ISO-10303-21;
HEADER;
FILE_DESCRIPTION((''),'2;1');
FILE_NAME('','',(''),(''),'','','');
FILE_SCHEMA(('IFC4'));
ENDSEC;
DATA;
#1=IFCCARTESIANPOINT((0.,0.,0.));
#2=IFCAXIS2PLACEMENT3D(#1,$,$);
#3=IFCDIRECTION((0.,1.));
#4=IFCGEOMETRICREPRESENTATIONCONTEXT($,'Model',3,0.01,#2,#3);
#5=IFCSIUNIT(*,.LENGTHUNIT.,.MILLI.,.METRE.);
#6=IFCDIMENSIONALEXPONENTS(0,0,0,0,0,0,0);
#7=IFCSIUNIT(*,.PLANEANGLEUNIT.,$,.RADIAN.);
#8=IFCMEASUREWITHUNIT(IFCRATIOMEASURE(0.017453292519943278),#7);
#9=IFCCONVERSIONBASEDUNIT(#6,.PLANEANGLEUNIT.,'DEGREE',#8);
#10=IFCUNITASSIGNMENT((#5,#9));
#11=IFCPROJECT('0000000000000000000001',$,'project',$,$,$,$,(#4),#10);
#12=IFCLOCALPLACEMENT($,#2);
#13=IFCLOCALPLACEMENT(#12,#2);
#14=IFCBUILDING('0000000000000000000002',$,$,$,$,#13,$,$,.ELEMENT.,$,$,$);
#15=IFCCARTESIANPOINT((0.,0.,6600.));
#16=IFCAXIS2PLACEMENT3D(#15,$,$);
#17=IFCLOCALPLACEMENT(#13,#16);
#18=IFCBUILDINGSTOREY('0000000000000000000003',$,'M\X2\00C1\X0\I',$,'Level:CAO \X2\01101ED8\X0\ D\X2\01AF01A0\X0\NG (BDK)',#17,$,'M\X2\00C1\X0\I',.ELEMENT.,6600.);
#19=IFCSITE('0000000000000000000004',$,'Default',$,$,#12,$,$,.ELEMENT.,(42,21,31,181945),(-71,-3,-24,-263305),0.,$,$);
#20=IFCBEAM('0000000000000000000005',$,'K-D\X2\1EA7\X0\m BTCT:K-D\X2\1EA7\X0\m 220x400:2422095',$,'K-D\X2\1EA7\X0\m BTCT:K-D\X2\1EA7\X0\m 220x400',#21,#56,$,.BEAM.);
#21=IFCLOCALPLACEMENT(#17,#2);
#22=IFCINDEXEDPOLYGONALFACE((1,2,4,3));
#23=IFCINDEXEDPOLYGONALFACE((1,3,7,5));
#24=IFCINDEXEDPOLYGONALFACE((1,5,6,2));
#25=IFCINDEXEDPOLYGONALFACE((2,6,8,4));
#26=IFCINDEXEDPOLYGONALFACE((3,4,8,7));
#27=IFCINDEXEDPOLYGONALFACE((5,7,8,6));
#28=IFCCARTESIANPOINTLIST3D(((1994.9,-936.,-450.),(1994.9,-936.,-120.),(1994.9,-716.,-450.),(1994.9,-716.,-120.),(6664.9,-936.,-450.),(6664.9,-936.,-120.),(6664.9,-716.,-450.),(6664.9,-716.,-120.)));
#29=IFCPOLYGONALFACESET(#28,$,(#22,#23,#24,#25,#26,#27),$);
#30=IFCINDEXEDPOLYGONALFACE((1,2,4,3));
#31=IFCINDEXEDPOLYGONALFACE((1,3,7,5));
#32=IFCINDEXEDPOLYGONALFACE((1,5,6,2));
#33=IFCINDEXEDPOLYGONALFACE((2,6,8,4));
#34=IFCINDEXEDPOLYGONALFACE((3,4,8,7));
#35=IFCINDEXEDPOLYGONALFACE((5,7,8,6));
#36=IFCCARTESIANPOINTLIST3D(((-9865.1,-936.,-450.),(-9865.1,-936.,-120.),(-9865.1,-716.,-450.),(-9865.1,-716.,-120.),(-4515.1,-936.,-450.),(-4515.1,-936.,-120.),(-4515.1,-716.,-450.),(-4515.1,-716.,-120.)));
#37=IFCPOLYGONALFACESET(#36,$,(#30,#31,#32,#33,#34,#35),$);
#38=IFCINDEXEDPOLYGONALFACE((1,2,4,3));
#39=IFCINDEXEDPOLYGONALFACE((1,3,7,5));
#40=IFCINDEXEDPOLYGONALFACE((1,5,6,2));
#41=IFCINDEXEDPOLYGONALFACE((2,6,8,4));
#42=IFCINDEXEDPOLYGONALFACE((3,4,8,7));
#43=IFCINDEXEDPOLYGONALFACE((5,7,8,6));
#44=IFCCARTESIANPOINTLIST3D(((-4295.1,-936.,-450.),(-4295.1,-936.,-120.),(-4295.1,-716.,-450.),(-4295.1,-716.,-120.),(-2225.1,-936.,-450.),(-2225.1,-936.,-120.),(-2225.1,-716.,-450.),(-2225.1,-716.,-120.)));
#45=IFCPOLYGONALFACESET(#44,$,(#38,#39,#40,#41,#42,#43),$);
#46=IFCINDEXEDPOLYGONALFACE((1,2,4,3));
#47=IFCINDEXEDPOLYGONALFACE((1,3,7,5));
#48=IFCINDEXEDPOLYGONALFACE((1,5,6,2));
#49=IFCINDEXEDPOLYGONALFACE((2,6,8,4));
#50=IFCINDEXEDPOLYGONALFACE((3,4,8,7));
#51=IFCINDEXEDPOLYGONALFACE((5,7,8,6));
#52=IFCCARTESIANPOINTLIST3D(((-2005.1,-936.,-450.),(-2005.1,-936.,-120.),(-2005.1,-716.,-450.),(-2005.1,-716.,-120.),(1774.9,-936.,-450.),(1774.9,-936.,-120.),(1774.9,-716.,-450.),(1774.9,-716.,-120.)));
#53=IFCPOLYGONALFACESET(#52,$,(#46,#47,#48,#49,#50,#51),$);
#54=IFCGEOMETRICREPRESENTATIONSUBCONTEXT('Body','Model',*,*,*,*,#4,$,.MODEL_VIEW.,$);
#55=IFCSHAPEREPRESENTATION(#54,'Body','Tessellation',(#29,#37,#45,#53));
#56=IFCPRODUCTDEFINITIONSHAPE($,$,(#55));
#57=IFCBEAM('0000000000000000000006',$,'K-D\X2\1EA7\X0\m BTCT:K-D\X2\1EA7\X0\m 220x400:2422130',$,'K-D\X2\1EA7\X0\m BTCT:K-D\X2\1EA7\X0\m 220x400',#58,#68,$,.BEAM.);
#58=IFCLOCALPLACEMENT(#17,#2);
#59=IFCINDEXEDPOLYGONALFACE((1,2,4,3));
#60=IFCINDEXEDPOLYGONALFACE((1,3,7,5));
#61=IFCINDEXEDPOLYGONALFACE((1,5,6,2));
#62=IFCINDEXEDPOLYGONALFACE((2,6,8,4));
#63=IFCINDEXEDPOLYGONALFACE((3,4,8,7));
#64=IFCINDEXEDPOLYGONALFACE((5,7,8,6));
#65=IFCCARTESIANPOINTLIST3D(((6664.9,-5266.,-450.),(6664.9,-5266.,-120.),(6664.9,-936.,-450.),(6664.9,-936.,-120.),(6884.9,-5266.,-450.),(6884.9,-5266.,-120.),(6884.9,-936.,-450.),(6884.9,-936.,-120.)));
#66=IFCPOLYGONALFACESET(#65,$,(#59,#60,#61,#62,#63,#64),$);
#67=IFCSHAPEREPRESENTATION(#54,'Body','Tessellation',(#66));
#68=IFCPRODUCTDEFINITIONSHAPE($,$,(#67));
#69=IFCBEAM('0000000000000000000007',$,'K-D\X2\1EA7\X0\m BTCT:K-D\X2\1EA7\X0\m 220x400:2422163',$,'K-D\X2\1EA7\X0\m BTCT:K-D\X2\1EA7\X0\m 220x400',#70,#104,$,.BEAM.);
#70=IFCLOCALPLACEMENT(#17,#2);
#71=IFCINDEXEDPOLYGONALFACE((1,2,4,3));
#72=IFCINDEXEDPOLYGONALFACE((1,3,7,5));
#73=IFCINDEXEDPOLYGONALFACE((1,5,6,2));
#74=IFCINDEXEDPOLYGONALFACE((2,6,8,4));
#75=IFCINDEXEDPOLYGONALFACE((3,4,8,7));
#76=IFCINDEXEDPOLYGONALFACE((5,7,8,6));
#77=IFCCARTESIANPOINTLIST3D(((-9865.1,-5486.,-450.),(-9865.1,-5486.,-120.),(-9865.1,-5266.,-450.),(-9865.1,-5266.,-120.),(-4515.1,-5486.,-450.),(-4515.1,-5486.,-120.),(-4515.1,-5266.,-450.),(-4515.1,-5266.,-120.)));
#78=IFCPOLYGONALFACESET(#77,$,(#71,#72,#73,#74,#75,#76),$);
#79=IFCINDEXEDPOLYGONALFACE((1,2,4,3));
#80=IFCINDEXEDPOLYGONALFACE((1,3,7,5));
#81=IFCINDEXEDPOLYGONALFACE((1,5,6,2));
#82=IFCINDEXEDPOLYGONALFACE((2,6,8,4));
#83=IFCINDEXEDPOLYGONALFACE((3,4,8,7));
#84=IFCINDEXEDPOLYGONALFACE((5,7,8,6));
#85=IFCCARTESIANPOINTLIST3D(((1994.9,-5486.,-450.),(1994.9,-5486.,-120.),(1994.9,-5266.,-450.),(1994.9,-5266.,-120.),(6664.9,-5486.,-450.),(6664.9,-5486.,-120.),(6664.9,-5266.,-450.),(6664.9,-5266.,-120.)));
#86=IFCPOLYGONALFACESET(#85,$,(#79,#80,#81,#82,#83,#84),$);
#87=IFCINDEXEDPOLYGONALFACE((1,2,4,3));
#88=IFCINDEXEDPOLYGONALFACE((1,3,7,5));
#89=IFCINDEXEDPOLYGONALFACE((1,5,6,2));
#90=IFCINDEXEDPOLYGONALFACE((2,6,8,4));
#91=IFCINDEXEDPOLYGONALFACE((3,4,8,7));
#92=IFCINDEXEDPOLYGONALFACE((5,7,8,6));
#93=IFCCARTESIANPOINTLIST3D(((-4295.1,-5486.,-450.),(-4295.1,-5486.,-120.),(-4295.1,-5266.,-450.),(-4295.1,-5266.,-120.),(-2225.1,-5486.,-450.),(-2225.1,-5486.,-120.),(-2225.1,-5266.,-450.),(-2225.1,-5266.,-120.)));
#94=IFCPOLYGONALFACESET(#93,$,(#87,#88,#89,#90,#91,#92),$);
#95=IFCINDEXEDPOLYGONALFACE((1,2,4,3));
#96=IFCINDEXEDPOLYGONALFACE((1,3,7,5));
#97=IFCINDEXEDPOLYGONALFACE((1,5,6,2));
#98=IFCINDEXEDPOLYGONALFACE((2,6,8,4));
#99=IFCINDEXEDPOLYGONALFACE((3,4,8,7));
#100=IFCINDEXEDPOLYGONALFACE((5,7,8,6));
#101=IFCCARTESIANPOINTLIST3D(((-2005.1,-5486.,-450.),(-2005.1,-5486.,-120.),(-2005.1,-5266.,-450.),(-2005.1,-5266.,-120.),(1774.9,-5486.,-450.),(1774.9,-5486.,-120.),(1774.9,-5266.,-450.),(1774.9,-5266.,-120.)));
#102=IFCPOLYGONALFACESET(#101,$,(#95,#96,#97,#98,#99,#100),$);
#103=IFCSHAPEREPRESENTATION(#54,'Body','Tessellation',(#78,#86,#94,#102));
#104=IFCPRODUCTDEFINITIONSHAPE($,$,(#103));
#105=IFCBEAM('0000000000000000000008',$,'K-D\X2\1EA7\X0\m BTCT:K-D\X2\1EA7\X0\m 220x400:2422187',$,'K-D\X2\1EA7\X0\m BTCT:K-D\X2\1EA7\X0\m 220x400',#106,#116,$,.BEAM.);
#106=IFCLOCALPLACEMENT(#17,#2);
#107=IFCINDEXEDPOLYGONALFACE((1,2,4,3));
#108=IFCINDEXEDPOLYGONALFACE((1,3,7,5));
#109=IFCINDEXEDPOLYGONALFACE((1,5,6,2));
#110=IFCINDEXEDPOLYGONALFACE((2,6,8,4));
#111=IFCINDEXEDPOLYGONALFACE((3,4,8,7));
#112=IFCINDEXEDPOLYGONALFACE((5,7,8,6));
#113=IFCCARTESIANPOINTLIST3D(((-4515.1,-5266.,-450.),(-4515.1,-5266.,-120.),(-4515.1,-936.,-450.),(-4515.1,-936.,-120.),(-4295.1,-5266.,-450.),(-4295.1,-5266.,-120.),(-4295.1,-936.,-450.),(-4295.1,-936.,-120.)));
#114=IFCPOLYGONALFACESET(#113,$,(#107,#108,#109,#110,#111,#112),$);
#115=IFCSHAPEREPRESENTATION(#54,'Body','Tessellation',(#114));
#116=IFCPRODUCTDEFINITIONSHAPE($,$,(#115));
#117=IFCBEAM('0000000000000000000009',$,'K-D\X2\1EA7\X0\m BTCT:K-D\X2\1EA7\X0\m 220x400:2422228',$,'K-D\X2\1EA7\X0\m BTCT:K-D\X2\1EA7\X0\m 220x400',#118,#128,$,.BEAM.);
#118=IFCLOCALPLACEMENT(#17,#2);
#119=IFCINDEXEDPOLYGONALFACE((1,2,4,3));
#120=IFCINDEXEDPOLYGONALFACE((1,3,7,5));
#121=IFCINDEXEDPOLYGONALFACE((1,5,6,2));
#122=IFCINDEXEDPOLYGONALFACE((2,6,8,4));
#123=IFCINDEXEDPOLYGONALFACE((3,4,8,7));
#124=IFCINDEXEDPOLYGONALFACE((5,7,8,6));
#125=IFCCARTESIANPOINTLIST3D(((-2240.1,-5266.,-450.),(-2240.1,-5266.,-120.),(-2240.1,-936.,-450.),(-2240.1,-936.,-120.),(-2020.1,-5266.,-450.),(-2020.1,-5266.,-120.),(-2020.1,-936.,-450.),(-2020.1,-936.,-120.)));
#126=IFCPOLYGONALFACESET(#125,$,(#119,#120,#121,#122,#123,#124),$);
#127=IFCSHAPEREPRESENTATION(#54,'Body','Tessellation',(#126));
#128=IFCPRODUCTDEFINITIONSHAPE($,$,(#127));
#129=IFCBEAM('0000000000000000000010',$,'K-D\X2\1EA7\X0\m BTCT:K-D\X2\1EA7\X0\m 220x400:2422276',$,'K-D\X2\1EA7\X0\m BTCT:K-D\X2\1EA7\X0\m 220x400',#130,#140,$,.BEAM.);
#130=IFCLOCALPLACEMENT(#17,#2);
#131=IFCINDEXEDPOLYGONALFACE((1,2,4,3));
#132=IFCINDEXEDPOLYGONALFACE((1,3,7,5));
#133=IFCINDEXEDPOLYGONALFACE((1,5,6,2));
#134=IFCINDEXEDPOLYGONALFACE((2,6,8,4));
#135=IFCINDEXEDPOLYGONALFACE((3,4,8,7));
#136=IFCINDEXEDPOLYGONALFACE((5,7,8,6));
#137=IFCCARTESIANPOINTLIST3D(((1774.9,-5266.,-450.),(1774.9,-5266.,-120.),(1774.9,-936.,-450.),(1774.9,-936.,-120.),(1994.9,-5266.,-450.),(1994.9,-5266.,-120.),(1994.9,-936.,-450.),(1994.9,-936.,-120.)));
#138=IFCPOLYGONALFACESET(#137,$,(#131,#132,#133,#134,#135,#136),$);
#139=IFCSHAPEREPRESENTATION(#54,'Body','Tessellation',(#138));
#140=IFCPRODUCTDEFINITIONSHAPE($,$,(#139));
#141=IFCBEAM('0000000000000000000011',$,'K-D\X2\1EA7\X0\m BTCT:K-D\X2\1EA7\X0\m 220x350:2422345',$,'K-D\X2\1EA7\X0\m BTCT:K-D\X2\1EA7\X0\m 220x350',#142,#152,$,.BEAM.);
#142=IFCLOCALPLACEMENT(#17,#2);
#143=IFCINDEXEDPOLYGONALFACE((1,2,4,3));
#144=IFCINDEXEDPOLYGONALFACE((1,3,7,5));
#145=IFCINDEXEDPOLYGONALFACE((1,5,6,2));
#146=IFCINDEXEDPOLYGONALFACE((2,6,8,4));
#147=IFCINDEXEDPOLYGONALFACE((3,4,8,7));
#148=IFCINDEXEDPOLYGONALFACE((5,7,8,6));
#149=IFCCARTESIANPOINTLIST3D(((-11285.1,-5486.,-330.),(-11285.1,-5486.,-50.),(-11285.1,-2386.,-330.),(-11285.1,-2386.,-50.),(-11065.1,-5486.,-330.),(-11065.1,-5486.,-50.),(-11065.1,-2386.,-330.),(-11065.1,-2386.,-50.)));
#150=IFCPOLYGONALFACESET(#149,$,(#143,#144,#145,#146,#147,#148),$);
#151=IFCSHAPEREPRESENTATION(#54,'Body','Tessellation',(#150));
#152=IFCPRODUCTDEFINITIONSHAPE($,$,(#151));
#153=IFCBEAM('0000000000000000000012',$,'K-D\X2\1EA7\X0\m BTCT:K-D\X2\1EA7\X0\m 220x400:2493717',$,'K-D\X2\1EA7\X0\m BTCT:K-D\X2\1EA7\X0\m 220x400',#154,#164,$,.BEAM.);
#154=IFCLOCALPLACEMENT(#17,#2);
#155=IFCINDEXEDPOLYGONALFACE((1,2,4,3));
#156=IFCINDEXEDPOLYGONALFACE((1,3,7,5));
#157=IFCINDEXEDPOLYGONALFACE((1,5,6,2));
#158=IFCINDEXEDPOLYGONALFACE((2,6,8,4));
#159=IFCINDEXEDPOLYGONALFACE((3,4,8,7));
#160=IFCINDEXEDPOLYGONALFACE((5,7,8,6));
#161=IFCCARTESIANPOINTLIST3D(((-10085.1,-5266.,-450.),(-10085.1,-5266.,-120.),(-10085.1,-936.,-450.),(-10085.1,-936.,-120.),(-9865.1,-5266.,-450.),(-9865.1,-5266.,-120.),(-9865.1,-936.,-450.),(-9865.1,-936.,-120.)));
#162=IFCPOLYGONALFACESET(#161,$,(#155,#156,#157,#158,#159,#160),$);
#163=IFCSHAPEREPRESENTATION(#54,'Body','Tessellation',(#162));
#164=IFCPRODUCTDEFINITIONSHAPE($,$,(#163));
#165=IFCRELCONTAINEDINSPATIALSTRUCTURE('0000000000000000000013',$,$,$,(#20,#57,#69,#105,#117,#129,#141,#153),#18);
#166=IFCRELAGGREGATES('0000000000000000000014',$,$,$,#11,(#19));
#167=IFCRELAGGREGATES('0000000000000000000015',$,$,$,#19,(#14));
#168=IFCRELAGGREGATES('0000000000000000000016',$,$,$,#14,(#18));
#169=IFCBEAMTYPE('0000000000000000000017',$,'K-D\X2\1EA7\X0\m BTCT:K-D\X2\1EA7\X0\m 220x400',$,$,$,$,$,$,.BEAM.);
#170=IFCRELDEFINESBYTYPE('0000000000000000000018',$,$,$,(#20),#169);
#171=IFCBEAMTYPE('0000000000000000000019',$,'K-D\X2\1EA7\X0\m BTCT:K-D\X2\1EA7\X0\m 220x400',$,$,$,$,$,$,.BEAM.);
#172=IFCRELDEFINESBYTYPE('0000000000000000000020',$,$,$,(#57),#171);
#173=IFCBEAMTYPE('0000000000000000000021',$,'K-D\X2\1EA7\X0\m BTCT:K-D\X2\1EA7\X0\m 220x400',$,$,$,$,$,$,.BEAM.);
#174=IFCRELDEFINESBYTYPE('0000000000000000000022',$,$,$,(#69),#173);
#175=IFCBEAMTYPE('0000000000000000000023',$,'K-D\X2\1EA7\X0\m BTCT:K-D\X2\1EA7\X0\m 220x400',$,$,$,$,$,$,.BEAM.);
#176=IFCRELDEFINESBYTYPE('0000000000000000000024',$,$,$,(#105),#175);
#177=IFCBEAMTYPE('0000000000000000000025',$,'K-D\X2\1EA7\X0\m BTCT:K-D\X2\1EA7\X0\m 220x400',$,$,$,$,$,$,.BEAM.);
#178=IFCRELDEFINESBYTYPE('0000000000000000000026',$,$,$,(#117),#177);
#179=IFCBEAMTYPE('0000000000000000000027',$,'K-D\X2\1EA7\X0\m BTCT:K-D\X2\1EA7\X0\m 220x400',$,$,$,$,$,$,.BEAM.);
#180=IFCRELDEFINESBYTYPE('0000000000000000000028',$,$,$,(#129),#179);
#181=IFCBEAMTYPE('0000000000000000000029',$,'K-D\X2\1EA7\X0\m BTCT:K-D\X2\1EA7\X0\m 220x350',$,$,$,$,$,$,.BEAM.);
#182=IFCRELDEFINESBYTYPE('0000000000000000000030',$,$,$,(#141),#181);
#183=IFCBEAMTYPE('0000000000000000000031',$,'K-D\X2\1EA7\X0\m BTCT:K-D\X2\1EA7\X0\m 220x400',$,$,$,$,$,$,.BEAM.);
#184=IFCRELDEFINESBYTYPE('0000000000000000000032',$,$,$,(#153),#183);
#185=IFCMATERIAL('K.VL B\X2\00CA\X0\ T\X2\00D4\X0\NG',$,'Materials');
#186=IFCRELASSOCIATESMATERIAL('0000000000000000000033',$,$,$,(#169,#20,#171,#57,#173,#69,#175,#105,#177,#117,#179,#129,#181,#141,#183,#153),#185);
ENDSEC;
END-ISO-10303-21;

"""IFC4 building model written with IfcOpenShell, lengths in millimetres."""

from ifc_helpers import new_model, entity, si_unit, converted_unit, direction, frame, origin, place, context, subcontext, project, spatial, indexed_curve, outline, extrude, source, transform, mapped, material, type_object, type_shapes, element, save


model = new_model("IFC4")

# Units and contexts
model_context = context("Model", 3, precision=0.01, world=origin(), true_north=direction((0.0, 1.0)))
body_context = subcontext(model_context, "Body", "Model", "MODEL_VIEW")
ifc_project = project(units=[si_unit("LENGTHUNIT", "METRE", prefix="MILLI"), converted_unit("PLANEANGLEUNIT", "DEGREE", entity("IfcRatioMeasure", 0.017453292519943278), si_unit("PLANEANGLEUNIT", "RADIAN"), dimensions=[0, 0, 0, 0, 0, 0, 0])], contexts=[model_context])

# Site, building, storey
site_placement = place(None, origin())
site = spatial("IfcSite", under=ifc_project, at=site_placement, Name="Default", CompositionType="ELEMENT", RefLatitude=(42, 21, 31, 181945), RefLongitude=(-71, -3, -24, -263305), RefElevation=0.0)
building_placement = place(site_placement, origin())
building = spatial("IfcBuilding", under=site, at=building_placement, CompositionType="ELEMENT")
storey_placement = place(building_placement, frame((0.0, 0.0, 6600.0)))
storey = spatial("IfcBuildingStorey", under=building, at=storey_placement, Name="MÁI", ObjectType="Level:CAO ĐỘ DƯƠNG (BDK)", LongName="MÁI", CompositionType="ELEMENT", Elevation=6600.0)

# Beams
ifc_material_1 = material(Name="K.VL BÊ TÔNG", Category="Materials")
beam_type_1 = type_object("IfcBeamType", Name="K-Dầm BTCT:K-Dầm 220x400", PredefinedType="BEAM", material=ifc_material_1)
shared_shape_1 = source(origin(), body_context, "Body", "SweptSolid", [
    extrude(outline(indexed_curve([(-165.0, -110.0), (165.0, -110.0), (165.0, 110.0), (-165.0, 110.0), (-165.0, -110.0)], self_intersect=False)), frame((1994.9, -826.0, 6315.0), z_axis=(1.0, 0.0, 0.0), x_axis=(0.0, 0.0, -1.0)), (0.0, 0.0, 1.0), 4670.0),
    extrude(outline(indexed_curve([(-165.0, -110.0), (165.0, -110.0), (165.0, 110.0), (-165.0, 110.0), (-165.0, -110.0)], self_intersect=False)), frame((-9865.1, -826.0, 6315.0), z_axis=(1.0, 0.0, 0.0), x_axis=(0.0, 0.0, -1.0)), (0.0, 0.0, 1.0), 5350.0),
    extrude(outline(indexed_curve([(-165.0, -110.0), (165.0, -110.0), (165.0, 110.0), (-165.0, 110.0), (-165.0, -110.0)], self_intersect=False)), frame((-4295.1, -826.0, 6315.0), z_axis=(1.0, 0.0, 0.0), x_axis=(0.0, 0.0, -1.0)), (0.0, 0.0, 1.0), 2070.0),
    extrude(outline(indexed_curve([(-165.0, -110.0), (165.0, -110.0), (165.0, 110.0), (-165.0, 110.0), (-165.0, -110.0)], self_intersect=False)), frame((-2005.1, -826.0, 6315.0), z_axis=(1.0, 0.0, 0.0), x_axis=(0.0, 0.0, -1.0)), (0.0, 0.0, 1.0), 3780.0),
])
type_shapes(beam_type_1, [shared_shape_1])
beam_1_placement = place(storey_placement, frame((0.0, 0.0, -6600.0)))
element("IfcBeam", 1, at=beam_1_placement, inside=storey, type_object=beam_type_1, material=ifc_material_1, Name="K-Dầm BTCT:K-Dầm 220x400:2422095", ObjectType="K-Dầm BTCT:K-Dầm 220x400", PredefinedType="BEAM", context=body_context, shape_type="MappedRepresentation", body=[
    mapped(shared_shape_1, transform((0.0, 0.0, 0.0), scale=1.0)),
])
beam_type_2 = type_object("IfcBeamType", Name="K-Dầm BTCT:K-Dầm 220x400", PredefinedType="BEAM", material=ifc_material_1)
shared_shape_2 = source(origin(), body_context, "Body", "SweptSolid", [
    extrude(outline(indexed_curve([(-110.0, -165.0), (110.0, -165.0), (110.0, 165.0), (-110.0, 165.0), (-110.0, -165.0)], self_intersect=False)), frame((6774.9, -936.0, 6315.0), z_axis=(0.0, -1.0, 0.0), x_axis=(-1.0, 0.0, 0.0)), (0.0, 0.0, 1.0), 4330.0),
])
type_shapes(beam_type_2, [shared_shape_2])
beam_2_placement = place(storey_placement, frame((0.0, 0.0, -6600.0)))
element("IfcBeam", 2, at=beam_2_placement, inside=storey, type_object=beam_type_2, material=ifc_material_1, Name="K-Dầm BTCT:K-Dầm 220x400:2422130", ObjectType="K-Dầm BTCT:K-Dầm 220x400", PredefinedType="BEAM", context=body_context, shape_type="MappedRepresentation", body=[
    mapped(shared_shape_2, transform((0.0, 0.0, 0.0), scale=1.0)),
])
beam_type_3 = type_object("IfcBeamType", Name="K-Dầm BTCT:K-Dầm 220x400", PredefinedType="BEAM", material=ifc_material_1)
shared_shape_3 = source(origin(), body_context, "Body", "SweptSolid", [
    extrude(outline(indexed_curve([(-165.0, -110.0), (165.0, -110.0), (165.0, 110.0), (-165.0, 110.0), (-165.0, -110.0)], self_intersect=False)), frame((-4515.1, -5376.0, 6315.0), z_axis=(-1.0, 0.0, 0.0), x_axis=(0.0, 0.0, -1.0)), (0.0, 0.0, 1.0), 5350.0),
    extrude(outline(indexed_curve([(-165.0, -110.0), (165.0, -110.0), (165.0, 110.0), (-165.0, 110.0), (-165.0, -110.0)], self_intersect=False)), frame((6664.9, -5376.0, 6315.0), z_axis=(-1.0, 0.0, 0.0), x_axis=(0.0, 0.0, -1.0)), (0.0, 0.0, 1.0), 4670.0),
    extrude(outline(indexed_curve([(-165.0, -110.0), (165.0, -110.0), (165.0, 110.0), (-165.0, 110.0), (-165.0, -110.0)], self_intersect=False)), frame((-2225.1, -5376.0, 6315.0), z_axis=(-1.0, 0.0, 0.0), x_axis=(0.0, 0.0, -1.0)), (0.0, 0.0, 1.0), 2070.0),
    extrude(outline(indexed_curve([(-165.0, -110.0), (165.0, -110.0), (165.0, 110.0), (-165.0, 110.0), (-165.0, -110.0)], self_intersect=False)), frame((1774.9, -5376.0, 6315.0), z_axis=(-1.0, 0.0, 0.0), x_axis=(0.0, 0.0, -1.0)), (0.0, 0.0, 1.0), 3780.0),
])
type_shapes(beam_type_3, [shared_shape_3])
beam_3_placement = place(storey_placement, frame((0.0, 0.0, -6600.0)))
element("IfcBeam", 3, at=beam_3_placement, inside=storey, type_object=beam_type_3, material=ifc_material_1, Name="K-Dầm BTCT:K-Dầm 220x400:2422163", ObjectType="K-Dầm BTCT:K-Dầm 220x400", PredefinedType="BEAM", context=body_context, shape_type="MappedRepresentation", body=[
    mapped(shared_shape_3, transform((0.0, 0.0, 0.0), scale=1.0)),
])
beam_type_4 = type_object("IfcBeamType", Name="K-Dầm BTCT:K-Dầm 220x400", PredefinedType="BEAM", material=ifc_material_1)
shared_shape_4 = source(origin(), body_context, "Body", "SweptSolid", [
    extrude(outline(indexed_curve([(-110.0, -165.0), (110.0, -165.0), (110.0, 165.0), (-110.0, 165.0), (-110.0, -165.0)], self_intersect=False)), frame((-4405.1, -936.0, 6315.0), z_axis=(0.0, -1.0, 0.0), x_axis=(-1.0, 0.0, 0.0)), (0.0, 0.0, 1.0), 4330.0),
])
type_shapes(beam_type_4, [shared_shape_4])
beam_4_placement = place(storey_placement, frame((0.0, 0.0, -6600.0)))
element("IfcBeam", 4, at=beam_4_placement, inside=storey, type_object=beam_type_4, material=ifc_material_1, Name="K-Dầm BTCT:K-Dầm 220x400:2422187", ObjectType="K-Dầm BTCT:K-Dầm 220x400", PredefinedType="BEAM", context=body_context, shape_type="MappedRepresentation", body=[
    mapped(shared_shape_4, transform((0.0, 0.0, 0.0), scale=1.0)),
])
beam_type_5 = type_object("IfcBeamType", Name="K-Dầm BTCT:K-Dầm 220x400", PredefinedType="BEAM", material=ifc_material_1)
shared_shape_5 = source(origin(), body_context, "Body", "SweptSolid", [
    extrude(outline(indexed_curve([(-110.0, -165.0), (110.0, -165.0), (110.0, 165.0), (-110.0, 165.0), (-110.0, -165.0)], self_intersect=False)), frame((-2130.1, -936.0, 6315.0), z_axis=(0.0, -1.0, 0.0), x_axis=(-1.0, 0.0, 0.0)), (0.0, 0.0, 1.0), 4330.0),
])
type_shapes(beam_type_5, [shared_shape_5])
beam_5_placement = place(storey_placement, frame((0.0, 0.0, -6600.0)))
element("IfcBeam", 5, at=beam_5_placement, inside=storey, type_object=beam_type_5, material=ifc_material_1, Name="K-Dầm BTCT:K-Dầm 220x400:2422228", ObjectType="K-Dầm BTCT:K-Dầm 220x400", PredefinedType="BEAM", context=body_context, shape_type="MappedRepresentation", body=[
    mapped(shared_shape_5, transform((0.0, 0.0, 0.0), scale=1.0)),
])
beam_type_6 = type_object("IfcBeamType", Name="K-Dầm BTCT:K-Dầm 220x400", PredefinedType="BEAM", material=ifc_material_1)
shared_shape_6 = source(origin(), body_context, "Body", "SweptSolid", [
    extrude(outline(indexed_curve([(-110.0, -165.0), (110.0, -165.0), (110.0, 165.0), (-110.0, 165.0), (-110.0, -165.0)], self_intersect=False)), frame((1884.9, -936.0, 6315.0), z_axis=(0.0, -1.0, 0.0), x_axis=(-1.0, 0.0, 0.0)), (0.0, 0.0, 1.0), 4330.0),
])
type_shapes(beam_type_6, [shared_shape_6])
beam_6_placement = place(storey_placement, frame((0.0, 0.0, -6600.0)))
element("IfcBeam", 6, at=beam_6_placement, inside=storey, type_object=beam_type_6, material=ifc_material_1, Name="K-Dầm BTCT:K-Dầm 220x400:2422276", ObjectType="K-Dầm BTCT:K-Dầm 220x400", PredefinedType="BEAM", context=body_context, shape_type="MappedRepresentation", body=[
    mapped(shared_shape_6, transform((0.0, 0.0, 0.0), scale=1.0)),
])
beam_type_7 = type_object("IfcBeamType", Name="K-Dầm BTCT:K-Dầm 220x350", PredefinedType="BEAM", material=ifc_material_1)
shared_shape_7 = source(origin(), body_context, "Body", "SweptSolid", [
    extrude(outline(indexed_curve([(-110.0, -140.0), (110.0, -140.0), (110.0, 140.0), (-110.0, 140.0), (-110.0, -140.0)], self_intersect=False)), frame((-11175.1, -5486.0, 6410.0), z_axis=(0.0, 1.0, 0.0), x_axis=(-1.0, 0.0, 0.0)), (0.0, 0.0, 1.0), 3100.0),
])
type_shapes(beam_type_7, [shared_shape_7])
beam_7_placement = place(storey_placement, frame((0.0, 0.0, -6600.0)))
element("IfcBeam", 7, at=beam_7_placement, inside=storey, type_object=beam_type_7, material=ifc_material_1, Name="K-Dầm BTCT:K-Dầm 220x350:2422345", ObjectType="K-Dầm BTCT:K-Dầm 220x350", PredefinedType="BEAM", context=body_context, shape_type="MappedRepresentation", body=[
    mapped(shared_shape_7, transform((0.0, 0.0, 0.0), scale=1.0)),
])
beam_type_8 = type_object("IfcBeamType", Name="K-Dầm BTCT:K-Dầm 220x400", PredefinedType="BEAM", material=ifc_material_1)
shared_shape_8 = source(origin(), body_context, "Body", "SweptSolid", [
    extrude(outline(indexed_curve([(-110.0, -165.0), (110.0, -165.0), (110.0, 165.0), (-110.0, 165.0), (-110.0, -165.0)], self_intersect=False)), frame((-9975.1, -936.0, 6315.0), z_axis=(0.0, -1.0, 0.0), x_axis=(-1.0, 0.0, 0.0)), (0.0, 0.0, 1.0), 4330.0),
])
type_shapes(beam_type_8, [shared_shape_8])
beam_8_placement = place(storey_placement, frame((0.0, 0.0, -6600.0)))
element("IfcBeam", 8, at=beam_8_placement, inside=storey, type_object=beam_type_8, material=ifc_material_1, Name="K-Dầm BTCT:K-Dầm 220x400:2493717", ObjectType="K-Dầm BTCT:K-Dầm 220x400", PredefinedType="BEAM", context=body_context, shape_type="MappedRepresentation", body=[
    mapped(shared_shape_8, transform((0.0, 0.0, 0.0), scale=1.0)),
])

save(model, "model.ifc")
